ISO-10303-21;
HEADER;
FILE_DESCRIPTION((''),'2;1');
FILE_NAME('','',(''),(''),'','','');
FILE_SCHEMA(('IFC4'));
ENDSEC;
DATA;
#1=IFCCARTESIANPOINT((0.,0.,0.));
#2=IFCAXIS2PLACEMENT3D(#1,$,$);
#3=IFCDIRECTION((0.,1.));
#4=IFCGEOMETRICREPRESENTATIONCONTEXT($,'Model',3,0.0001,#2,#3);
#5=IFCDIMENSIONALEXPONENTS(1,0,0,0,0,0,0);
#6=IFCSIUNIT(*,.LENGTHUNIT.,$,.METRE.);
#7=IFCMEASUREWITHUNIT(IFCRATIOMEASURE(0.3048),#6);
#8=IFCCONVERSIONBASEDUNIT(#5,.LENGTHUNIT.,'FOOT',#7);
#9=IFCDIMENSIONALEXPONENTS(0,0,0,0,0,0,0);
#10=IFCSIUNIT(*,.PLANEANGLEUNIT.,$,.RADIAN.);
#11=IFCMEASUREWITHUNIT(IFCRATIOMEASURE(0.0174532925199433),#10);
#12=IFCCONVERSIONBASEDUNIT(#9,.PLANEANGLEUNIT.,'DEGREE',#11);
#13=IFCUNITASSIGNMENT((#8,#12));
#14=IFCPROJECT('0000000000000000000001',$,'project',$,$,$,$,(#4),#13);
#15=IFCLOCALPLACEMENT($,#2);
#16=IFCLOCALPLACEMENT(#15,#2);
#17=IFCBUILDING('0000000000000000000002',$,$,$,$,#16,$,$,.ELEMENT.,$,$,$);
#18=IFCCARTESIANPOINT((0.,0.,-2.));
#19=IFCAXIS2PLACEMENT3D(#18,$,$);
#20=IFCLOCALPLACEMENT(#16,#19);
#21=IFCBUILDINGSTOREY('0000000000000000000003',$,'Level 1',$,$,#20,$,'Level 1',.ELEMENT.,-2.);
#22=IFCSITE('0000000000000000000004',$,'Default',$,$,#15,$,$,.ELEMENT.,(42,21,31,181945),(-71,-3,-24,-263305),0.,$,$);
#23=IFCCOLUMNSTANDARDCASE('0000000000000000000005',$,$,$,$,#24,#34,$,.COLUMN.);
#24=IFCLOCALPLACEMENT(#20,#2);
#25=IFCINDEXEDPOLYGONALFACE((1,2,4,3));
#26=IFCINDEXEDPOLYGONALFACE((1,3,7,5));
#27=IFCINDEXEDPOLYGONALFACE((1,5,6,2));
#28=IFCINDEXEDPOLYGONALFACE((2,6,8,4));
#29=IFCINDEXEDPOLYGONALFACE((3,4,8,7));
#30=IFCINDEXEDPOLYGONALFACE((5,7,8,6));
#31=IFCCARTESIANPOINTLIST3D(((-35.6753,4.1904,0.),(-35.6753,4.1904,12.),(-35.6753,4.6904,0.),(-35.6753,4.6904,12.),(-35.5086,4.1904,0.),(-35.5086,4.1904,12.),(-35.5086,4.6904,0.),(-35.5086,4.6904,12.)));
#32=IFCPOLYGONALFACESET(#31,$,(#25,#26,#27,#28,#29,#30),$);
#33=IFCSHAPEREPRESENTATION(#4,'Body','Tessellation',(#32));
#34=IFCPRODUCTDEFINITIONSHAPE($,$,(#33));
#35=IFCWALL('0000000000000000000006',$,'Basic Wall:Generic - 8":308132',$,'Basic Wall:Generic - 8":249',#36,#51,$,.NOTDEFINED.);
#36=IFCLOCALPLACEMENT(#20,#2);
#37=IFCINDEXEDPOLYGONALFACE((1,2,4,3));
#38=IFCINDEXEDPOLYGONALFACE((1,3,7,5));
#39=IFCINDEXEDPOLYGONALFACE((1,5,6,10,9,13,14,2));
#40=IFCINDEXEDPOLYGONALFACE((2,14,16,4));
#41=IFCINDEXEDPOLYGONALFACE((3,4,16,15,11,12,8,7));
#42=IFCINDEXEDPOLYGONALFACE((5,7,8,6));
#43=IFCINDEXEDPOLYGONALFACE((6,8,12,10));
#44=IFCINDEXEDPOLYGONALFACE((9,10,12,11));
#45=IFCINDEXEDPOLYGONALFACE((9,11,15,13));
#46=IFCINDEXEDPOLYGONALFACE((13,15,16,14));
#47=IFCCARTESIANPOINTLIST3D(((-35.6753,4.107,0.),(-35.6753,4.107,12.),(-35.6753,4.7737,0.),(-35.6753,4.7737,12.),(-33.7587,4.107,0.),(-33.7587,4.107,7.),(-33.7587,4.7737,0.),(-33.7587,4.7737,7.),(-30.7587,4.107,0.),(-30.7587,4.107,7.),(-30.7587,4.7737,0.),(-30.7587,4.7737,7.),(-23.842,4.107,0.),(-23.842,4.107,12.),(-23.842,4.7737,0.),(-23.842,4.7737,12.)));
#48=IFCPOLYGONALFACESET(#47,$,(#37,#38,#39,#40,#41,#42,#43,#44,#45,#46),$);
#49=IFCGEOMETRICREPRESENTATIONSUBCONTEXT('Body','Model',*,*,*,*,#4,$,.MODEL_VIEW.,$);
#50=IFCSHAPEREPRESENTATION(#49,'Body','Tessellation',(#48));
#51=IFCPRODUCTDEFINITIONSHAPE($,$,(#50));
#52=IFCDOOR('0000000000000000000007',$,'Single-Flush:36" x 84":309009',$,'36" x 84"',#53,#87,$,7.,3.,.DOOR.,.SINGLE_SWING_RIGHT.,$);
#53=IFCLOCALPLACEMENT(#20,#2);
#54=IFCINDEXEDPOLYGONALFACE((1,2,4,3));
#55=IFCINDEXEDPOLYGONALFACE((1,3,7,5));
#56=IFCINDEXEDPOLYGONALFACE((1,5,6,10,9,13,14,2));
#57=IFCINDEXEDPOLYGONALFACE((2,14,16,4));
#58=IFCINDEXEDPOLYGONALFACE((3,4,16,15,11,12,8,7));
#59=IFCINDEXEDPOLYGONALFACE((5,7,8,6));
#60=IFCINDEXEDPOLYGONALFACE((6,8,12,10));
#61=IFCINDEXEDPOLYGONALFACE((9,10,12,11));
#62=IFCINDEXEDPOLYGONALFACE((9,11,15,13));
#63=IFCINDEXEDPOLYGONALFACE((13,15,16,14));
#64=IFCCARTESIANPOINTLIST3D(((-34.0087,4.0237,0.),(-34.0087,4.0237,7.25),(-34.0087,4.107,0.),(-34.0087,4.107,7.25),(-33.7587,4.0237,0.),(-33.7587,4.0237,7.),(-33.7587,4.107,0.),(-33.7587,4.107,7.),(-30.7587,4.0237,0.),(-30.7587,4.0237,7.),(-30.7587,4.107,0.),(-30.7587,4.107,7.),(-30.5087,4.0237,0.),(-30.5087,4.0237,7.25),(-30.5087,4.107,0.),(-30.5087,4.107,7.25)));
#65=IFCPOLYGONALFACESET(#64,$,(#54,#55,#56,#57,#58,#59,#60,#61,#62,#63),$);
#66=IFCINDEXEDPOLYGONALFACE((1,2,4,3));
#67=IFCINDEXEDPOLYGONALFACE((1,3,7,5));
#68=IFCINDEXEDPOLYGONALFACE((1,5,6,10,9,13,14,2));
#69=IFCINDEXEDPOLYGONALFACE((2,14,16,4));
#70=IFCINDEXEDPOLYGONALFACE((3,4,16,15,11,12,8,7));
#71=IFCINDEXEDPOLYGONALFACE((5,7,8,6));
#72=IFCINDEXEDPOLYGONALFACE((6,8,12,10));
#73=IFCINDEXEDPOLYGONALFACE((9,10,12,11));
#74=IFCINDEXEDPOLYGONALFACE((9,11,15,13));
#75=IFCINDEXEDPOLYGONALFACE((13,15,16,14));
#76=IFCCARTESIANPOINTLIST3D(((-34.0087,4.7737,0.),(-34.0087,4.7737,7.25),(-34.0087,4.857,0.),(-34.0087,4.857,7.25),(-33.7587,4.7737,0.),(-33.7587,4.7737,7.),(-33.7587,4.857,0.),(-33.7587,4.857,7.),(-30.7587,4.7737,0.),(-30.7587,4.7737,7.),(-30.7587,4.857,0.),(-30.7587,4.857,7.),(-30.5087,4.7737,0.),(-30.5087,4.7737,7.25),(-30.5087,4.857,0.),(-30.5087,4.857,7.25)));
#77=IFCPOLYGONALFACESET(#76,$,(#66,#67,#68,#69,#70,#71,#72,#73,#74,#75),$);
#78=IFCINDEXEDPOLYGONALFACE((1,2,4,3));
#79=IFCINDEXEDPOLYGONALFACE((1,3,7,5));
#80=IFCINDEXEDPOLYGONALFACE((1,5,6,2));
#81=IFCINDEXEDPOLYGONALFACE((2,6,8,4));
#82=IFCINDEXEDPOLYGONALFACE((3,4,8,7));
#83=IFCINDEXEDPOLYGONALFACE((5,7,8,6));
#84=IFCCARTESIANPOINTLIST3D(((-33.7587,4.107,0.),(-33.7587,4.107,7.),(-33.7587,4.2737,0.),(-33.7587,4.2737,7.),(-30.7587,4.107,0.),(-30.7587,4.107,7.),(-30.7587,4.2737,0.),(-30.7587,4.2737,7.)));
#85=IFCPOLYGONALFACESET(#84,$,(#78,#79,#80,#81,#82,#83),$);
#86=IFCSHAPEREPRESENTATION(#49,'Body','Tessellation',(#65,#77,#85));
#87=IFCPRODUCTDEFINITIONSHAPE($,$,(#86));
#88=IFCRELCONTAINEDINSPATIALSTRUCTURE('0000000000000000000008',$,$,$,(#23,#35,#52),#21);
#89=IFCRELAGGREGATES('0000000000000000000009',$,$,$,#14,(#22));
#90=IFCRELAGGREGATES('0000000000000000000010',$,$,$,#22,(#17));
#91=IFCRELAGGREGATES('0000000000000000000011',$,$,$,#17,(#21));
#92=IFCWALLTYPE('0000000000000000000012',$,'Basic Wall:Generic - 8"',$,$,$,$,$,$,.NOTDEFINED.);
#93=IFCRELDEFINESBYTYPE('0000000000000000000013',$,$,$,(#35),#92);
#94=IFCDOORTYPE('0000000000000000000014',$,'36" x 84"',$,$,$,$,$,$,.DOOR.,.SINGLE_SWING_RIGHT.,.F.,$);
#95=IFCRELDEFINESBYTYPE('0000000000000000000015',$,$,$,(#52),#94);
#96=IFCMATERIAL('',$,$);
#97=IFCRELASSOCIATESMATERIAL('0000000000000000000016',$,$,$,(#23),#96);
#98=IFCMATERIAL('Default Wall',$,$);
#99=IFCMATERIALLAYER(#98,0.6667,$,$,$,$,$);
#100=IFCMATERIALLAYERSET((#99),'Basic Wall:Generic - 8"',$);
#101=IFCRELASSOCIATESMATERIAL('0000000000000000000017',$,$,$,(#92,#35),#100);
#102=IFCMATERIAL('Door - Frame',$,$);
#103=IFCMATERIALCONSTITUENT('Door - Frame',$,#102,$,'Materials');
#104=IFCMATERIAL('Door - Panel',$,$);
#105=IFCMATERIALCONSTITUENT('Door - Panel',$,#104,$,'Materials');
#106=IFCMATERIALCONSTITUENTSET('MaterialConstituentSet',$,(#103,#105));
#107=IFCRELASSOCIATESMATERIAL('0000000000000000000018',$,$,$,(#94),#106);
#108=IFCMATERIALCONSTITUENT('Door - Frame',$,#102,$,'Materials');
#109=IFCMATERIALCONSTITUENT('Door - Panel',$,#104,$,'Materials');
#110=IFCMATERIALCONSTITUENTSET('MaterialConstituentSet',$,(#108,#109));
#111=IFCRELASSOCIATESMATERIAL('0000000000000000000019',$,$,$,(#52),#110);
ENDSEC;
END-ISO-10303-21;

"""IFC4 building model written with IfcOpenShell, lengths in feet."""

from ifc_helpers import new_model, entity, si_unit, converted_unit, direction, frame, frame_2d, origin, place, context, subcontext, project, spatial, polyline, rectangle, outline, extrude, source, transform, mapped, material, layer, layer_set, layer_usage, constituent, constituent_set, type_object, type_shapes, element, fill, save


model = new_model("IFC4")

# Units and contexts
model_context = context("Model", 3, precision=0.0001, world=origin(), true_north=direction((0.0, 1.0)))
body_context = subcontext(model_context, "Body", "Model", "MODEL_VIEW")
ifc_project = project(units=[converted_unit("LENGTHUNIT", "FOOT", entity("IfcRatioMeasure", 0.3048), si_unit("LENGTHUNIT", "METRE"), dimensions=[1, 0, 0, 0, 0, 0, 0]), converted_unit("PLANEANGLEUNIT", "DEGREE", entity("IfcRatioMeasure", 0.0174532925199433), si_unit("PLANEANGLEUNIT", "RADIAN"), dimensions=[0, 0, 0, 0, 0, 0, 0])], contexts=[model_context])

# Site, building, storey
site_placement = place(None, origin())
site = spatial("IfcSite", under=ifc_project, at=site_placement, Name="Default", CompositionType="ELEMENT", RefLatitude=(42, 21, 31, 181945), RefLongitude=(-71, -3, -24, -263305), RefElevation=0.0)
building_placement = place(site_placement, origin())
building = spatial("IfcBuilding", under=site, at=building_placement, CompositionType="ELEMENT")
storey_placement = place(building_placement, frame((0.0, 0.0, -2.0)))
storey = spatial("IfcBuildingStorey", under=building, at=storey_placement, Name="Level 1", LongName="Level 1", CompositionType="ELEMENT", Elevation=-2.0)

# Column
ifc_material_1 = material(Name="")
wall_placement = place(storey_placement, frame((-35.6753, 4.4404, 0.0)))
column_placement = place(wall_placement, frame((0.0833, 0.0, 0.0), z_axis=(0.0, 0.0, 1.0), x_axis=(1.0, 0.0, 0.0)))
element("IfcColumnStandardCase", 1, at=column_placement, inside=storey, material=ifc_material_1, PredefinedType="COLUMN", context=model_context, shape_type="SweptSolid", body=[
    extrude(rectangle(XDim=0.1667, YDim=0.5), origin(), (0.0, 0.0, 1.0), 12.0),
])

# Wall, opening, door
ifc_material_2 = material(Name="Default Wall")
ifc_layer = layer(ifc_material_2, 0.6667)
ifc_layer_set = layer_set([ifc_layer], Name="Basic Wall:Generic - 8\"")
ifc_layer_usage = layer_usage(ifc_layer_set, "AXIS2", "NEGATIVE", 0.3333)
wall_type = type_object("IfcWallType", Name="Basic Wall:Generic - 8\"", PredefinedType="NOTDEFINED", material=ifc_layer_set)
wall = element("IfcWall", 2, at=wall_placement, inside=storey, type_object=wall_type, material=ifc_layer_usage, Name="Basic Wall:Generic - 8\":308132", ObjectType="Basic Wall:Generic - 8\":249", PredefinedType="NOTDEFINED", context=body_context, shape_type="SweptSolid", body=[
    extrude(rectangle(XDim=11.8333, YDim=0.6667, at=frame_2d((5.9167, 0.0), x_axis=(-1.0, 0.0))), origin(), (0.0, 0.0, 1.0), 12.0),
])
opening_placement = place(wall_placement, frame((4.9167, 0.3333, 0.0)))
opening = element("IfcOpeningElement", 3, at=opening_placement, cuts=wall, ObjectType="Opening", PredefinedType="OPENING", context=body_context, shape_type="SweptSolid", body=[
    extrude(rectangle(XDim=3.0, YDim=7.0, at=frame_2d((3.5, 1.5), x_axis=(0.0, 1.0))), frame((0.0, 0.0, 0.0), z_axis=(0.0, -1.0, 0.0), x_axis=(0.0, 0.0, 1.0)), (0.0, 0.0, 1.0), 0.6667),
])
ifc_material_3 = material(Name="Door - Frame")
ifc_constituent_1 = constituent(ifc_material_3, Name="Door - Frame", Category="Materials")
ifc_material_4 = material(Name="Door - Panel")
ifc_constituent_2 = constituent(ifc_material_4, Name="Door - Panel", Category="Materials")
ifc_constituent_set_1 = constituent_set(constituents=[ifc_constituent_1, ifc_constituent_2], Name="MaterialConstituentSet")
ifc_constituent_3 = constituent(ifc_material_3, Name="Door - Frame", Category="Materials")
ifc_constituent_4 = constituent(ifc_material_4, Name="Door - Panel", Category="Materials")
ifc_constituent_set_2 = constituent_set(constituents=[ifc_constituent_3, ifc_constituent_4], Name="MaterialConstituentSet")
door_type = type_object("IfcDoorType", Name="36\" x 84\"", OperationType="SINGLE_SWING_RIGHT", ParameterTakesPrecedence=False, PredefinedType="DOOR", material=ifc_constituent_set_2)
shared_shape = source(origin(), body_context, "Body", "SweptSolid", [
    extrude(outline(polyline([(-1.75, -3.6875), (1.75, -3.6875), (1.75, 3.5625), (1.5, 3.5625), (1.5, -3.4375), (-1.5, -3.4375), (-1.5, 3.5625), (-1.75, 3.5625), (-1.75, -3.6875)])), frame((1.5, 0.6667, 3.5625), z_axis=(0.0, 1.0, 0.0), x_axis=(1.0, 0.0, 0.0)), (0.0, 0.0, 1.0), 0.0833),
    extrude(outline(polyline([(-3.6875, -1.75), (3.5625, -1.75), (3.5625, -1.5), (-3.4375, -1.5), (-3.4375, 1.5), (3.5625, 1.5), (3.5625, 1.75), (-3.6875, 1.75), (-3.6875, -1.75)])), frame((1.5, -0.0833, 3.5625), z_axis=(0.0, 1.0, 0.0), x_axis=(0.0, 0.0, -1.0)), (0.0, 0.0, 1.0), 0.0833),
    extrude(rectangle(XDim=0.1667, YDim=3.0, at=frame_2d((0.0, 0.0), x_axis=(1.0, 0.0))), frame((1.5, 0.5833, 0.0), z_axis=(0.0, 0.0, 1.0), x_axis=(0.0, 1.0, 0.0)), (0.0, 0.0, 1.0), 7.0),
])
type_shapes(door_type, [shared_shape])
door_placement = place(opening_placement, frame((0.0, 0.0, 0.0), z_axis=(0.0, 0.0, 1.0), x_axis=(-1.0, 0.0, 0.0)))
door = element("IfcDoor", 4, at=door_placement, inside=storey, type_object=door_type, material=ifc_constituent_set_1, Name="Single-Flush:36\" x 84\":309009", ObjectType="36\" x 84\"", OperationType="SINGLE_SWING_RIGHT", OverallHeight=7.0, OverallWidth=3.0, PredefinedType="DOOR", context=body_context, shape_type="MappedRepresentation", body=[
    mapped(shared_shape, transform((0.0, 0.0, 0.0), scale=1.0)),
])
fill(opening, door)

save(model, "model.ifc")
